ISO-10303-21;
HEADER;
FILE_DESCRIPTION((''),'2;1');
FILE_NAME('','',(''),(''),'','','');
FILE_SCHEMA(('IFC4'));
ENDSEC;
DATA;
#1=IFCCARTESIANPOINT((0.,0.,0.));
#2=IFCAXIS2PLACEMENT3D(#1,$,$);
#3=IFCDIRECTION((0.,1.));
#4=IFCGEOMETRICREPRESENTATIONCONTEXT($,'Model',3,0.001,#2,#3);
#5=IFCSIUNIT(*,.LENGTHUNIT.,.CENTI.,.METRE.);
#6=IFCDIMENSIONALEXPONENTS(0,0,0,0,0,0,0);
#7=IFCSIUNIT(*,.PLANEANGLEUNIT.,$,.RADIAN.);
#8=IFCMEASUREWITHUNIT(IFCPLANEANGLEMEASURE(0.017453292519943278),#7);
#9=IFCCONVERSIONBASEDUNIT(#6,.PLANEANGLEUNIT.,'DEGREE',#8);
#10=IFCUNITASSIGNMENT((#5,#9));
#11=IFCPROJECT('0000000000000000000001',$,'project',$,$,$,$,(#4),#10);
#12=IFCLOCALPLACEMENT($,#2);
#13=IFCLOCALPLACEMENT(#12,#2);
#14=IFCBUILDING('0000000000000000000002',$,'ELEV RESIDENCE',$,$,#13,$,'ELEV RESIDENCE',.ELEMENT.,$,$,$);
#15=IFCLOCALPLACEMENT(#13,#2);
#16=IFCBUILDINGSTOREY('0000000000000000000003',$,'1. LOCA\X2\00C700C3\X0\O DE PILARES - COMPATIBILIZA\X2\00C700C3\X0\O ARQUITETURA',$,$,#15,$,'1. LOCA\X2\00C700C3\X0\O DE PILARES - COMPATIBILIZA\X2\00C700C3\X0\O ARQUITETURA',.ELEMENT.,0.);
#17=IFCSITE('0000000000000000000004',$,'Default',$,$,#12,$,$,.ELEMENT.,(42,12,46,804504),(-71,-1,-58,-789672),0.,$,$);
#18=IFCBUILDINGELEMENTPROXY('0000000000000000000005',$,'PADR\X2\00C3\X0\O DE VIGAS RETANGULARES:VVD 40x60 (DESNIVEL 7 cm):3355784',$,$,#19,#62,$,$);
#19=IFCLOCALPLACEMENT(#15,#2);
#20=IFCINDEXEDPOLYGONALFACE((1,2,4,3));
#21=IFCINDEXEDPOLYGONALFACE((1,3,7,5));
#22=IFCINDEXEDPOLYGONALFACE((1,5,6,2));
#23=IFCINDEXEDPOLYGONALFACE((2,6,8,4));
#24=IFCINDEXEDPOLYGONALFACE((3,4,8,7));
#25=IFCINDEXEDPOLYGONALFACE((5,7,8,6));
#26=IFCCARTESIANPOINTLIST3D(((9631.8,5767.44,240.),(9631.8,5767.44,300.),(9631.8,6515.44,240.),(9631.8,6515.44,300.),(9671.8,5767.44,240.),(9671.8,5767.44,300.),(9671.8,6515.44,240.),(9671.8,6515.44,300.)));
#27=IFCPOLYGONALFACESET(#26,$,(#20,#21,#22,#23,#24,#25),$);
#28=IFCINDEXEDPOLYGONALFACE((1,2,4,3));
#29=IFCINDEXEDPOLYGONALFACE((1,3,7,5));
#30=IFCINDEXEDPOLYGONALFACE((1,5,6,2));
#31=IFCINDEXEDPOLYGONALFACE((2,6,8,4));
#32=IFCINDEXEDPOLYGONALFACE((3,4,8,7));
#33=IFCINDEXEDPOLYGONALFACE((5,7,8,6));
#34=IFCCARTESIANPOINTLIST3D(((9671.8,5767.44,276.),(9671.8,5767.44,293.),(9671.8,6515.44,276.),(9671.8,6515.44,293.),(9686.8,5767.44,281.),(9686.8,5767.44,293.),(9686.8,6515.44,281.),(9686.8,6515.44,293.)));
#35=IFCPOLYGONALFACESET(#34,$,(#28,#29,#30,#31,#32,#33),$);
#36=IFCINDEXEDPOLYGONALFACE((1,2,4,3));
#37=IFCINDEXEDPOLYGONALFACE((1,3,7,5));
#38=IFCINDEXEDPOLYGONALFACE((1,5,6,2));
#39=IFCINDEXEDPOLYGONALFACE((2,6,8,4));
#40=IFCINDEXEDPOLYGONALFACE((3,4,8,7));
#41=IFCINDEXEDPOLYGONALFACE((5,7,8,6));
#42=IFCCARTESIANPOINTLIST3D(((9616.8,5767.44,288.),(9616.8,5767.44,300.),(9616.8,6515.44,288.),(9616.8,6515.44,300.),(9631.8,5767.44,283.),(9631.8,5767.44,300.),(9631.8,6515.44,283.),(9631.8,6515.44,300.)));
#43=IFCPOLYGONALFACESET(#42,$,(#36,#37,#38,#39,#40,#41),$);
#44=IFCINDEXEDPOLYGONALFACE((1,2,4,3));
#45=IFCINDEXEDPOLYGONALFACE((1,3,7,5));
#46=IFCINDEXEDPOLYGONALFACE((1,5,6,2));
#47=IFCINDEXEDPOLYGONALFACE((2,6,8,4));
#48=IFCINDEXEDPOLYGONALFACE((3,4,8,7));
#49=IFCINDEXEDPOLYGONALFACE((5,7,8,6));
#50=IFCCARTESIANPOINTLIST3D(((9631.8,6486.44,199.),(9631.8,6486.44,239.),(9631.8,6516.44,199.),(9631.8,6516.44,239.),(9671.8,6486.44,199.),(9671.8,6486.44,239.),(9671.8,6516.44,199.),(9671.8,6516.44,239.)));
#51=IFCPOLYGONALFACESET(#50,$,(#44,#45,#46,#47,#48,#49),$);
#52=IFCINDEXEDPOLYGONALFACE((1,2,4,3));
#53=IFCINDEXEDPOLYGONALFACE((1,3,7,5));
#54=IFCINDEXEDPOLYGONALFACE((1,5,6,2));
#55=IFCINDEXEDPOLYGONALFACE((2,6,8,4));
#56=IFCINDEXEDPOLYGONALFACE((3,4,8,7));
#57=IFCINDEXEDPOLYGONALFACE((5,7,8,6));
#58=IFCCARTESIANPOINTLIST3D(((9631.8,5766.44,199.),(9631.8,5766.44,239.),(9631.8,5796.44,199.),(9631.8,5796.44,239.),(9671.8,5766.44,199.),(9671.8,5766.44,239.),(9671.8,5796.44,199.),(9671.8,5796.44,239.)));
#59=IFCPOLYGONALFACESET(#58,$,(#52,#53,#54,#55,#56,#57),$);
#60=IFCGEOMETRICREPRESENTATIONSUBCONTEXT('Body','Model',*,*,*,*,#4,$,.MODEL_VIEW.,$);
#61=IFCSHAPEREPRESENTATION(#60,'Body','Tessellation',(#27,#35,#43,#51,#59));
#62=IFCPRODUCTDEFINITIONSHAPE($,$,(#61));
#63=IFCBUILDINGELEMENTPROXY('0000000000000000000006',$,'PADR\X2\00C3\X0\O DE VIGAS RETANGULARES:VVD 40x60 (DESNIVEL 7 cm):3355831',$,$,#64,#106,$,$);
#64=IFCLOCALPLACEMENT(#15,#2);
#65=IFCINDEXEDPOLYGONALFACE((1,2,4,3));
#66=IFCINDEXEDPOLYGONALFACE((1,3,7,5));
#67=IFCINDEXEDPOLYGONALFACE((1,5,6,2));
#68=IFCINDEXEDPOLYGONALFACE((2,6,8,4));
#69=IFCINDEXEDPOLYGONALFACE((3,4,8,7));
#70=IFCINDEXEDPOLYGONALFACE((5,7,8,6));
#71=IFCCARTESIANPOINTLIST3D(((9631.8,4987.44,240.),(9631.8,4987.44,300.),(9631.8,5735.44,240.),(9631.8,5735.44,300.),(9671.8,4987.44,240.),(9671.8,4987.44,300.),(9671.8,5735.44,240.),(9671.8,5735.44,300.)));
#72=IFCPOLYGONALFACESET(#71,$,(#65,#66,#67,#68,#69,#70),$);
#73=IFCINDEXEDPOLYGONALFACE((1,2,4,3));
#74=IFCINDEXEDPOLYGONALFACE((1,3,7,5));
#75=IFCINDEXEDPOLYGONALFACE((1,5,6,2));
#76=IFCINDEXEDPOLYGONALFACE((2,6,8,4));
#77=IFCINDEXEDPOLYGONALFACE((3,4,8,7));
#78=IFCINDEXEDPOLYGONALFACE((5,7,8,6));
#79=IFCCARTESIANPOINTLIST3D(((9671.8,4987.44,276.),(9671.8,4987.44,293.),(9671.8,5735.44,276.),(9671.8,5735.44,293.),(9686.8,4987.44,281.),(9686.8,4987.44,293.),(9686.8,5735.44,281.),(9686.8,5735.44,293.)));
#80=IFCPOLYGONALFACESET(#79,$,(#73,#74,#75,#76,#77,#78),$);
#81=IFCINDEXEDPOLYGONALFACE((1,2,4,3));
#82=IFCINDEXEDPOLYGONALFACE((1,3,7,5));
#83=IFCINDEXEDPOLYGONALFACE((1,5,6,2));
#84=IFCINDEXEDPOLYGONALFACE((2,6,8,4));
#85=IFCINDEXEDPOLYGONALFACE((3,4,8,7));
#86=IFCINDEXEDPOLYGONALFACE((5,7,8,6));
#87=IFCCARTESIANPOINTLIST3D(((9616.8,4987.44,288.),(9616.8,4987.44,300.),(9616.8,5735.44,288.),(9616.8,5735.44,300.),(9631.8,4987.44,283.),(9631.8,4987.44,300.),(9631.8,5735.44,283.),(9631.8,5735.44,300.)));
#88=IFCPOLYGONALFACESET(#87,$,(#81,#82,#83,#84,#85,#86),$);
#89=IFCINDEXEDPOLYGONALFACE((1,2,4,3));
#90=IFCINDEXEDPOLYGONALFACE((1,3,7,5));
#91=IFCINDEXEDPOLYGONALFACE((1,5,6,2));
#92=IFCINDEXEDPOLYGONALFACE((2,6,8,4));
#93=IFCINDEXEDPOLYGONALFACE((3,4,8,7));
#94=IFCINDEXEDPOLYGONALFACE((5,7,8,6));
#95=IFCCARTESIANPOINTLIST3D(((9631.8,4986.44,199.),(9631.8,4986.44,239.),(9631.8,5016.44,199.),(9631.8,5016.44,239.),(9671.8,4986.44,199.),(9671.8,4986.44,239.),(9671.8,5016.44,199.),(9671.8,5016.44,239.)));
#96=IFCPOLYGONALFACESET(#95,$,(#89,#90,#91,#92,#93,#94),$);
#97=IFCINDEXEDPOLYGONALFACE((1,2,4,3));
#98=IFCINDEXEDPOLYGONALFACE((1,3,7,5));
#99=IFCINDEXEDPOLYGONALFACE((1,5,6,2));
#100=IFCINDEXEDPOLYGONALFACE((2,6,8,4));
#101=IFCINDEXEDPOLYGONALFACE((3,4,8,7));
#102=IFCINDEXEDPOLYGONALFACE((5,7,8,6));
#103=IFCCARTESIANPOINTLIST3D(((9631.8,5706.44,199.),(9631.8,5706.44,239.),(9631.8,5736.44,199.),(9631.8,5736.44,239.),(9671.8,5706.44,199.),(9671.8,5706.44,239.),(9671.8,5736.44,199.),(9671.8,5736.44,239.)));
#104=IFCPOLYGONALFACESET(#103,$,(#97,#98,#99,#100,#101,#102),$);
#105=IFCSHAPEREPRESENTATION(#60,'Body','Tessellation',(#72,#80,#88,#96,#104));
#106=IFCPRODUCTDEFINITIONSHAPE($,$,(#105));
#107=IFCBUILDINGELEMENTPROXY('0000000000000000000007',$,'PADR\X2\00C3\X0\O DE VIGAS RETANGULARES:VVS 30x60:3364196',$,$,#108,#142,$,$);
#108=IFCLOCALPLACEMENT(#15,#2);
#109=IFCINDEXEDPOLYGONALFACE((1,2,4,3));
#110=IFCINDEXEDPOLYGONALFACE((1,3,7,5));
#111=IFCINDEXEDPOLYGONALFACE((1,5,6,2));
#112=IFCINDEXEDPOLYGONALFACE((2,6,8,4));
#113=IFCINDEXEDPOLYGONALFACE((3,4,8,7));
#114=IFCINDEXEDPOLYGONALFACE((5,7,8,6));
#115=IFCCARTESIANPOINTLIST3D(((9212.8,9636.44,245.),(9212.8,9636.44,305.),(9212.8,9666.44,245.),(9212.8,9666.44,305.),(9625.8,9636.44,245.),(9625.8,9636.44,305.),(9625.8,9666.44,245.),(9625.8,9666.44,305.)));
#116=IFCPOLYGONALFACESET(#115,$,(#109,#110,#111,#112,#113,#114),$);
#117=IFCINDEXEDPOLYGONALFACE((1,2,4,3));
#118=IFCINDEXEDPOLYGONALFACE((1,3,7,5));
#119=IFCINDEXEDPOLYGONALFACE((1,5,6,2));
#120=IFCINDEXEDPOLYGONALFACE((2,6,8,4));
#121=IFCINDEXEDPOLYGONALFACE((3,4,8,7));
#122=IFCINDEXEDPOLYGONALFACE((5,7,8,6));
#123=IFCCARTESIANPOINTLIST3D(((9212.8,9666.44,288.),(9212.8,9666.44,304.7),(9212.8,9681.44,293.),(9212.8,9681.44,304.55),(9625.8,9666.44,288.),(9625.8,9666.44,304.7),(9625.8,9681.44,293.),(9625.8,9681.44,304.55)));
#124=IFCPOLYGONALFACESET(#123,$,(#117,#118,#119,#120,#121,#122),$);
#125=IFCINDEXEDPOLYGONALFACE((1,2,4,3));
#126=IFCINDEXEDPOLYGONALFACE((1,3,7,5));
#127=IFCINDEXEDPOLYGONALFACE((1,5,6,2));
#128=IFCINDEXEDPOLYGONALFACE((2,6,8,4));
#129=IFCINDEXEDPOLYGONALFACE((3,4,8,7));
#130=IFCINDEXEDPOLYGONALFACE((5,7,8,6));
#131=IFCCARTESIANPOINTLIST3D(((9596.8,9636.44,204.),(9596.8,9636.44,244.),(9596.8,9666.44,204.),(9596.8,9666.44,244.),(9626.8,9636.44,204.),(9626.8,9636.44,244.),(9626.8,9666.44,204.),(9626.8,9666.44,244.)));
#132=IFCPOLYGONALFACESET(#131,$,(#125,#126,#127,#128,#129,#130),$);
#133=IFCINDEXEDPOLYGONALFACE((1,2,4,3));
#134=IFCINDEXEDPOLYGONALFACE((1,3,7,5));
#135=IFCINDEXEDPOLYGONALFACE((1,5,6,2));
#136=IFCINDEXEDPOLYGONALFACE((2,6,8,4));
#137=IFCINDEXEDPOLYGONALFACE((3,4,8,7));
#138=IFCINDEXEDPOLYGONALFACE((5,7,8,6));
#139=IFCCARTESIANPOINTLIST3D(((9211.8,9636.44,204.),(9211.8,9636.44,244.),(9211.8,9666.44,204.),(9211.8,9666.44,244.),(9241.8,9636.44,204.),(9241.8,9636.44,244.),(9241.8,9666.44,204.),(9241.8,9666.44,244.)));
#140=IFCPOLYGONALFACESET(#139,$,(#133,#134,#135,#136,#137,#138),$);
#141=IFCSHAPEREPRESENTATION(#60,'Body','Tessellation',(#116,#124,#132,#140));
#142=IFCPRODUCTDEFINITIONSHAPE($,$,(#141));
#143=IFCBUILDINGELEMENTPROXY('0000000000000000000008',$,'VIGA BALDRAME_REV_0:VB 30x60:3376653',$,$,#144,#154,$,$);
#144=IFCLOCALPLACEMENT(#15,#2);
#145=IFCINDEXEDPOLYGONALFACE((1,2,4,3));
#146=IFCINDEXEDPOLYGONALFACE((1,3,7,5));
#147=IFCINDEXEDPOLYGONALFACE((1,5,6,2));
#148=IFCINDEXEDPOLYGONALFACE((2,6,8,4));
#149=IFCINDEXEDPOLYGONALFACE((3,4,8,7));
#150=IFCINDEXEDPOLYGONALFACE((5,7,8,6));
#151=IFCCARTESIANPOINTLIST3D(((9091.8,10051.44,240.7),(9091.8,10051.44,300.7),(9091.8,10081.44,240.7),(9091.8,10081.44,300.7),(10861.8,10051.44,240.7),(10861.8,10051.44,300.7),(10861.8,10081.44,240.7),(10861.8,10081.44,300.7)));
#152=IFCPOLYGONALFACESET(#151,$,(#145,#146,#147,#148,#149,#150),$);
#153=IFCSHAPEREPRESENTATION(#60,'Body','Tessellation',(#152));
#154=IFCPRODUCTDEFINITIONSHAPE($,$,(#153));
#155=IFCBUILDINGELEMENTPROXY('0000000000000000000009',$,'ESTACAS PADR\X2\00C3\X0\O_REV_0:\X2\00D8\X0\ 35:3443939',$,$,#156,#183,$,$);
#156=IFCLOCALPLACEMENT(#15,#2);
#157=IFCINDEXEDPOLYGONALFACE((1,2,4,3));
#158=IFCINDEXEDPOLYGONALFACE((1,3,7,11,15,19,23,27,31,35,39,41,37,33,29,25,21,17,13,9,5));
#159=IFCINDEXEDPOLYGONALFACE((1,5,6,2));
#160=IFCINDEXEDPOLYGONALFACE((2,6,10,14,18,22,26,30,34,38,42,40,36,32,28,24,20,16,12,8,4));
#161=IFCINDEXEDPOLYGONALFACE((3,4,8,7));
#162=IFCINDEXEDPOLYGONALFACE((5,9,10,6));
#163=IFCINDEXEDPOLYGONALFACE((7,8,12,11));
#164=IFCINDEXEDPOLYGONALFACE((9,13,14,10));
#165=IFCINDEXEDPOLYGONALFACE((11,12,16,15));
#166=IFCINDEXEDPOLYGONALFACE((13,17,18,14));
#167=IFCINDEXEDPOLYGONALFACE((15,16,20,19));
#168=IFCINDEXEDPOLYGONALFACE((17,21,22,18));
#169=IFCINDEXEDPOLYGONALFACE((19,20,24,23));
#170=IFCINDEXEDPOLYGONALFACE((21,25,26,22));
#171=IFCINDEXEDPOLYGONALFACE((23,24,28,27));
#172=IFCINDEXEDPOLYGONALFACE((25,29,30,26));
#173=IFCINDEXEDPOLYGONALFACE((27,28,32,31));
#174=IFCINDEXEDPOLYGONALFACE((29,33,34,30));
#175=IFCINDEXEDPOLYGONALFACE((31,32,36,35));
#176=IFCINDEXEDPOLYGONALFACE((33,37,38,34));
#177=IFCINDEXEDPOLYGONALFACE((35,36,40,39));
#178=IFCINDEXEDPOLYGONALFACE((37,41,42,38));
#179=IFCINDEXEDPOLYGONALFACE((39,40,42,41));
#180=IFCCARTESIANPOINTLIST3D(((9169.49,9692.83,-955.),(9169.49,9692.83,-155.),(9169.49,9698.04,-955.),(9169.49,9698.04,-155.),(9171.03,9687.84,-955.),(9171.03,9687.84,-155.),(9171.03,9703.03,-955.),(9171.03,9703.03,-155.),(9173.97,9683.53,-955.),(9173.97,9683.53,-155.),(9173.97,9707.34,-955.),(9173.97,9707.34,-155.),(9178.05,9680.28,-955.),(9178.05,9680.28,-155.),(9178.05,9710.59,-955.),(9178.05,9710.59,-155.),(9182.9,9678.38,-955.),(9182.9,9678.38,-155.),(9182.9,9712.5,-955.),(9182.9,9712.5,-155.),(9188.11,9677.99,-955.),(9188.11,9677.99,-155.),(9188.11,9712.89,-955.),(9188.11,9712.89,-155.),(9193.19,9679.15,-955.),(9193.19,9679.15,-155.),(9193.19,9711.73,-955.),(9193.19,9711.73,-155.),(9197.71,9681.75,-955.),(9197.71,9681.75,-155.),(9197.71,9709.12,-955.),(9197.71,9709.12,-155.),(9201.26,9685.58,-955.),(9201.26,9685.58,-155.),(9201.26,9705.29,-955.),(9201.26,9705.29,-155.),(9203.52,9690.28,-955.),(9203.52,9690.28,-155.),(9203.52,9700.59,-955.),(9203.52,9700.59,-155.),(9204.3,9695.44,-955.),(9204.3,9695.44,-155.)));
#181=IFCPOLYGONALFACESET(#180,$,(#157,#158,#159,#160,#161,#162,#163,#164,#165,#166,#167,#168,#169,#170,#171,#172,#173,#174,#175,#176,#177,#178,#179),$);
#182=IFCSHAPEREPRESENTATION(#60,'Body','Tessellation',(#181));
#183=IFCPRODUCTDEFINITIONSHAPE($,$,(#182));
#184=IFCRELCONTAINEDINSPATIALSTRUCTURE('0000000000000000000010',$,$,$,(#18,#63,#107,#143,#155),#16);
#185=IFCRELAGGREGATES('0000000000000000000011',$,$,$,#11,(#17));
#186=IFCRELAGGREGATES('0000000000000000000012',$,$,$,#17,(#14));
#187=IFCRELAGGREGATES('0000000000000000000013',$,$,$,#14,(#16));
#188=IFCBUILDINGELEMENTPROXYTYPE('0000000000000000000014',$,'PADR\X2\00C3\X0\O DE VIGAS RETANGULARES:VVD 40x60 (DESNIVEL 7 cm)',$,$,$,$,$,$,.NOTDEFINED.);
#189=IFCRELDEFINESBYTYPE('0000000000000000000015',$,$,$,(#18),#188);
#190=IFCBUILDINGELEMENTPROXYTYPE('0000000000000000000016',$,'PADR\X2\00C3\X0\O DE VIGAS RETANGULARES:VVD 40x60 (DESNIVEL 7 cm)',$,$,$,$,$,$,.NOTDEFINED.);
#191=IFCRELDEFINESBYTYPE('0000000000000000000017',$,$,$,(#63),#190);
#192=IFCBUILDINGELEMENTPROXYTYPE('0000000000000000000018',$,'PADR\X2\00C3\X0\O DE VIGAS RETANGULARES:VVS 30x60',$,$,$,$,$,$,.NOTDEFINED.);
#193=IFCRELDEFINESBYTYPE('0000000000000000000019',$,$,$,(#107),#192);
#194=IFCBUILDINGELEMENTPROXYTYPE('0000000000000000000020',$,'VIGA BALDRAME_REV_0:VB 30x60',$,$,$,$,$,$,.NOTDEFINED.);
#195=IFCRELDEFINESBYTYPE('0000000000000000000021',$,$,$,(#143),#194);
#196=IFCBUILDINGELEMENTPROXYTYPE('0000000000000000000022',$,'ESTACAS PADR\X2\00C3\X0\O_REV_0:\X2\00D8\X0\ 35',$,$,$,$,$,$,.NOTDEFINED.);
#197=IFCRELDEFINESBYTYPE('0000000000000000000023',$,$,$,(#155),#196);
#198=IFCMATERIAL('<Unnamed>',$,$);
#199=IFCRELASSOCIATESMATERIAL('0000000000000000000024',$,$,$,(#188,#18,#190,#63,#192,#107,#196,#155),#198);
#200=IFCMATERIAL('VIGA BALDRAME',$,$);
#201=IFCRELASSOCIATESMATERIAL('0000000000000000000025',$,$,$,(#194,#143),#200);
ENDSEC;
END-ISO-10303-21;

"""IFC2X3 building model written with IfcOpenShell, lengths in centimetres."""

from ifc_helpers import new_model, entity, si_unit, converted_unit, direction, frame, frame_2d, origin, origin_2d_with_axis, place, context, subcontext, project, spatial, polyline, rectangle, circle, outline, extrude, source, transform, mapped, material, type_object, type_shapes, element, save


model = new_model("IFC2X3")

# Units and contexts
model_context = context("Model", 3, precision=0.001, world=origin(), true_north=direction((0.0, 1.0)))
body_context = subcontext(model_context, "Body", "Model", "MODEL_VIEW")
ifc_project = project(units=[si_unit("LENGTHUNIT", "METRE", prefix="CENTI"), converted_unit("PLANEANGLEUNIT", "DEGREE", entity("IfcPlaneAngleMeasure", 0.017453292519943278), si_unit("PLANEANGLEUNIT", "RADIAN"), dimensions=[0, 0, 0, 0, 0, 0, 0])], contexts=[model_context])

# Site, building, storey
site_placement = place(None, origin())
site = spatial("IfcSite", under=ifc_project, at=site_placement, Name="Default", CompositionType="ELEMENT", RefLatitude=(42, 12, 46, 804504), RefLongitude=(-71, -1, -58, -789672), RefElevation=0.0)
building_placement = place(site_placement, origin())
building = spatial("IfcBuilding", under=site, at=building_placement, Name="ELEV RESIDENCE", LongName="ELEV RESIDENCE", CompositionType="ELEMENT")
storey_placement = place(building_placement, origin())
storey = spatial("IfcBuildingStorey", under=building, at=storey_placement, Name="1. LOCAÇÃO DE PILARES - COMPATIBILIZAÇÃO ARQUITETURA", LongName="1. LOCAÇÃO DE PILARES - COMPATIBILIZAÇÃO ARQUITETURA", CompositionType="ELEMENT", Elevation=0.0)

# Building element proxies
ifc_material_1 = material(Name="<Unnamed>")
building_element_proxy_type_1 = type_object("IfcBuildingElementProxyType", Name="PADRÃO DE VIGAS RETANGULARES:VVD 40x60 (DESNIVEL 7 cm)", PredefinedType="NOTDEFINED", material=ifc_material_1)
shared_shape_1 = source(origin(), body_context, "Body", "SweptSolid", [
    extrude(rectangle(XDim=40.0, YDim=748.0, at=frame_2d((0.0, 0.0), x_axis=(1.0, 0.0))), frame((9651.8, 6141.44, 240.0)), (0.0, 0.0, 1.0), 60.0),
    extrude(outline(polyline([(-7.25, -7.5), (4.75, -7.5), (9.75, 7.5), (-7.25, 7.5), (-7.25, -7.5)])), frame((9679.3, 5767.44, 285.75), z_axis=(0.0, 1.0, 0.0), x_axis=(0.0, 0.0, -1.0)), (0.0, 0.0, 1.0), 748.0),
    extrude(outline(polyline([(-7.5, -7.25), (7.5, -7.25), (7.5, 9.75), (-7.5, 4.75), (-7.5, -7.25)])), frame((9624.3, 5767.44, 292.75), z_axis=(0.0, 1.0, 0.0), x_axis=(1.0, 0.0, 0.0)), (0.0, 0.0, 1.0), 748.0),
    extrude(rectangle(XDim=30.0, YDim=40.0, at=frame_2d((0.0, 0.0), x_axis=(1.0, 0.0))), frame((9651.8, 6501.44, 199.0), z_axis=(0.0, 0.0, 1.0), x_axis=(0.0, 1.0, 0.0)), (0.0, 0.0, 1.0), 40.0),
    extrude(rectangle(XDim=30.0, YDim=40.0, at=frame_2d((0.0, 0.0), x_axis=(1.0, 0.0))), frame((9651.8, 5781.44, 199.0), z_axis=(0.0, 0.0, 1.0), x_axis=(0.0, 1.0, 0.0)), (0.0, 0.0, 1.0), 40.0),
])
type_shapes(building_element_proxy_type_1, [shared_shape_1])
proxy_1_placement = place(storey_placement, origin())
element("IfcBuildingElementProxy", 1, at=proxy_1_placement, inside=storey, type_object=building_element_proxy_type_1, material=ifc_material_1, Name="PADRÃO DE VIGAS RETANGULARES:VVD 40x60 (DESNIVEL 7 cm):3355784", context=body_context, shape_type="MappedRepresentation", body=[
    mapped(shared_shape_1, transform((0.0, 0.0, 0.0), scale=1.0)),
])
building_element_proxy_type_2 = type_object("IfcBuildingElementProxyType", Name="PADRÃO DE VIGAS RETANGULARES:VVD 40x60 (DESNIVEL 7 cm)", PredefinedType="NOTDEFINED", material=ifc_material_1)
shared_shape_2 = source(origin(), body_context, "Body", "SweptSolid", [
    extrude(rectangle(XDim=748.0, YDim=40.0, at=frame_2d((0.0, 0.0), x_axis=(1.0, 0.0))), frame((9651.8, 5361.44, 240.0), z_axis=(0.0, 0.0, 1.0), x_axis=(0.0, -1.0, 0.0)), (0.0, 0.0, 1.0), 60.0),
    extrude(outline(polyline([(-7.25, -7.5), (4.75, -7.5), (9.75, 7.5), (-7.25, 7.5), (-7.25, -7.5)])), frame((9679.3, 4987.44, 285.75), z_axis=(0.0, 1.0, 0.0), x_axis=(0.0, 0.0, -1.0)), (0.0, 0.0, 1.0), 748.0),
    extrude(outline(polyline([(-7.5, -7.25), (7.5, -7.25), (7.5, 9.75), (-7.5, 4.75), (-7.5, -7.25)])), frame((9624.3, 4987.44, 292.75), z_axis=(0.0, 1.0, 0.0), x_axis=(1.0, 0.0, 0.0)), (0.0, 0.0, 1.0), 748.0),
    extrude(rectangle(XDim=40.0, YDim=30.0, at=frame_2d((0.0, 0.0), x_axis=(1.0, 0.0))), frame((9651.8, 5001.44, 199.0), z_axis=(0.0, 0.0, 1.0), x_axis=(-1.0, 0.0, 0.0)), (0.0, 0.0, 1.0), 40.0),
    extrude(rectangle(XDim=40.0, YDim=30.0, at=frame_2d((0.0, 0.0), x_axis=(1.0, 0.0))), frame((9651.8, 5721.44, 199.0), z_axis=(0.0, 0.0, 1.0), x_axis=(-1.0, 0.0, 0.0)), (0.0, 0.0, 1.0), 40.0),
])
type_shapes(building_element_proxy_type_2, [shared_shape_2])
proxy_2_placement = place(storey_placement, origin())
element("IfcBuildingElementProxy", 2, at=proxy_2_placement, inside=storey, type_object=building_element_proxy_type_2, material=ifc_material_1, Name="PADRÃO DE VIGAS RETANGULARES:VVD 40x60 (DESNIVEL 7 cm):3355831", context=body_context, shape_type="MappedRepresentation", body=[
    mapped(shared_shape_2, transform((0.0, 0.0, 0.0), scale=1.0)),
])
building_element_proxy_type_3 = type_object("IfcBuildingElementProxyType", Name="PADRÃO DE VIGAS RETANGULARES:VVS 30x60", PredefinedType="NOTDEFINED", material=ifc_material_1)
shared_shape_3 = source(origin(), body_context, "Body", "SweptSolid", [
    extrude(rectangle(XDim=413.0, YDim=30.0, at=frame_2d((0.0, 0.0), x_axis=(1.0, 0.0))), frame((9419.3, 9651.44, 245.0)), (0.0, 0.0, 1.0), 60.0),
    extrude(outline(polyline([(-4.56, -7.5), (6.99, -7.5), (7.14, 7.5), (-9.56, 7.5), (-4.56, -7.5)])), frame((9212.8, 9673.94, 297.56), z_axis=(1.0, 0.0, 0.0), x_axis=(0.0, 0.0, 1.0)), (0.0, 0.0, 1.0), 413.0),
    extrude(rectangle(XDim=30.0, YDim=30.0, at=origin_2d_with_axis()), frame((9611.8, 9651.44, 204.0), z_axis=(0.0, 0.0, 1.0), x_axis=(0.0, -1.0, 0.0)), (0.0, 0.0, 1.0), 40.0),
    extrude(rectangle(XDim=30.0, YDim=30.0, at=frame_2d((0.0, 0.0), x_axis=(1.0, 0.0))), frame((9226.8, 9651.44, 204.0), z_axis=(0.0, 0.0, 1.0), x_axis=(0.0, -1.0, 0.0)), (0.0, 0.0, 1.0), 40.0),
])
type_shapes(building_element_proxy_type_3, [shared_shape_3])
proxy_3_placement = place(storey_placement, origin())
element("IfcBuildingElementProxy", 3, at=proxy_3_placement, inside=storey, type_object=building_element_proxy_type_3, material=ifc_material_1, Name="PADRÃO DE VIGAS RETANGULARES:VVS 30x60:3364196", context=body_context, shape_type="MappedRepresentation", body=[
    mapped(shared_shape_3, transform((0.0, 0.0, 0.0), scale=1.0)),
])
ifc_material_2 = material(Name="VIGA BALDRAME")
building_element_proxy_type_4 = type_object("IfcBuildingElementProxyType", Name="VIGA BALDRAME_REV_0:VB 30x60", PredefinedType="NOTDEFINED", material=ifc_material_2)
shared_shape_4 = source(origin(), body_context, "Body", "SweptSolid", [
    extrude(rectangle(XDim=1770.0, YDim=30.0, at=frame_2d((0.0, 0.0), x_axis=(1.0, 0.0))), frame((9976.8, 10066.44, 240.7), z_axis=(0.0, 0.0, 1.0), x_axis=(-1.0, 0.0, 0.0)), (0.0, 0.0, 1.0), 60.0),
])
type_shapes(building_element_proxy_type_4, [shared_shape_4])
proxy_4_placement = place(storey_placement, origin())
element("IfcBuildingElementProxy", 4, at=proxy_4_placement, inside=storey, type_object=building_element_proxy_type_4, material=ifc_material_2, Name="VIGA BALDRAME_REV_0:VB 30x60:3376653", context=body_context, shape_type="MappedRepresentation", body=[
    mapped(shared_shape_4, transform((0.0, 0.0, 0.0), scale=1.0)),
])
building_element_proxy_type_5 = type_object("IfcBuildingElementProxyType", Name="ESTACAS PADRÃO_REV_0:Ø 35", PredefinedType="NOTDEFINED", material=ifc_material_1)
shared_shape_5 = source(origin(), body_context, "Body", "SweptSolid", [
    extrude(circle(Radius=17.5, at=frame_2d((0.0, 0.0), x_axis=(1.0, 0.0))), frame((0.0, 0.0, -955.0)), (0.0, 0.0, 1.0), 800.0),
])
type_shapes(building_element_proxy_type_5, [shared_shape_5])
for number, where, name in (
    (5, (9186.8, 9695.44, 0.0), "ESTACAS PADRÃO_REV_0:Ø 35:3443939"),
):
    element("IfcBuildingElementProxy", number, at=place(storey_placement, frame(where)), inside=storey, type_object=building_element_proxy_type_5, material=ifc_material_1, Name=name, context=body_context, shape_type="MappedRepresentation", body=[
        mapped(shared_shape_5, transform((0.0, 0.0, 0.0), scale=1.0)),
    ])

save(model, "model.ifc")
